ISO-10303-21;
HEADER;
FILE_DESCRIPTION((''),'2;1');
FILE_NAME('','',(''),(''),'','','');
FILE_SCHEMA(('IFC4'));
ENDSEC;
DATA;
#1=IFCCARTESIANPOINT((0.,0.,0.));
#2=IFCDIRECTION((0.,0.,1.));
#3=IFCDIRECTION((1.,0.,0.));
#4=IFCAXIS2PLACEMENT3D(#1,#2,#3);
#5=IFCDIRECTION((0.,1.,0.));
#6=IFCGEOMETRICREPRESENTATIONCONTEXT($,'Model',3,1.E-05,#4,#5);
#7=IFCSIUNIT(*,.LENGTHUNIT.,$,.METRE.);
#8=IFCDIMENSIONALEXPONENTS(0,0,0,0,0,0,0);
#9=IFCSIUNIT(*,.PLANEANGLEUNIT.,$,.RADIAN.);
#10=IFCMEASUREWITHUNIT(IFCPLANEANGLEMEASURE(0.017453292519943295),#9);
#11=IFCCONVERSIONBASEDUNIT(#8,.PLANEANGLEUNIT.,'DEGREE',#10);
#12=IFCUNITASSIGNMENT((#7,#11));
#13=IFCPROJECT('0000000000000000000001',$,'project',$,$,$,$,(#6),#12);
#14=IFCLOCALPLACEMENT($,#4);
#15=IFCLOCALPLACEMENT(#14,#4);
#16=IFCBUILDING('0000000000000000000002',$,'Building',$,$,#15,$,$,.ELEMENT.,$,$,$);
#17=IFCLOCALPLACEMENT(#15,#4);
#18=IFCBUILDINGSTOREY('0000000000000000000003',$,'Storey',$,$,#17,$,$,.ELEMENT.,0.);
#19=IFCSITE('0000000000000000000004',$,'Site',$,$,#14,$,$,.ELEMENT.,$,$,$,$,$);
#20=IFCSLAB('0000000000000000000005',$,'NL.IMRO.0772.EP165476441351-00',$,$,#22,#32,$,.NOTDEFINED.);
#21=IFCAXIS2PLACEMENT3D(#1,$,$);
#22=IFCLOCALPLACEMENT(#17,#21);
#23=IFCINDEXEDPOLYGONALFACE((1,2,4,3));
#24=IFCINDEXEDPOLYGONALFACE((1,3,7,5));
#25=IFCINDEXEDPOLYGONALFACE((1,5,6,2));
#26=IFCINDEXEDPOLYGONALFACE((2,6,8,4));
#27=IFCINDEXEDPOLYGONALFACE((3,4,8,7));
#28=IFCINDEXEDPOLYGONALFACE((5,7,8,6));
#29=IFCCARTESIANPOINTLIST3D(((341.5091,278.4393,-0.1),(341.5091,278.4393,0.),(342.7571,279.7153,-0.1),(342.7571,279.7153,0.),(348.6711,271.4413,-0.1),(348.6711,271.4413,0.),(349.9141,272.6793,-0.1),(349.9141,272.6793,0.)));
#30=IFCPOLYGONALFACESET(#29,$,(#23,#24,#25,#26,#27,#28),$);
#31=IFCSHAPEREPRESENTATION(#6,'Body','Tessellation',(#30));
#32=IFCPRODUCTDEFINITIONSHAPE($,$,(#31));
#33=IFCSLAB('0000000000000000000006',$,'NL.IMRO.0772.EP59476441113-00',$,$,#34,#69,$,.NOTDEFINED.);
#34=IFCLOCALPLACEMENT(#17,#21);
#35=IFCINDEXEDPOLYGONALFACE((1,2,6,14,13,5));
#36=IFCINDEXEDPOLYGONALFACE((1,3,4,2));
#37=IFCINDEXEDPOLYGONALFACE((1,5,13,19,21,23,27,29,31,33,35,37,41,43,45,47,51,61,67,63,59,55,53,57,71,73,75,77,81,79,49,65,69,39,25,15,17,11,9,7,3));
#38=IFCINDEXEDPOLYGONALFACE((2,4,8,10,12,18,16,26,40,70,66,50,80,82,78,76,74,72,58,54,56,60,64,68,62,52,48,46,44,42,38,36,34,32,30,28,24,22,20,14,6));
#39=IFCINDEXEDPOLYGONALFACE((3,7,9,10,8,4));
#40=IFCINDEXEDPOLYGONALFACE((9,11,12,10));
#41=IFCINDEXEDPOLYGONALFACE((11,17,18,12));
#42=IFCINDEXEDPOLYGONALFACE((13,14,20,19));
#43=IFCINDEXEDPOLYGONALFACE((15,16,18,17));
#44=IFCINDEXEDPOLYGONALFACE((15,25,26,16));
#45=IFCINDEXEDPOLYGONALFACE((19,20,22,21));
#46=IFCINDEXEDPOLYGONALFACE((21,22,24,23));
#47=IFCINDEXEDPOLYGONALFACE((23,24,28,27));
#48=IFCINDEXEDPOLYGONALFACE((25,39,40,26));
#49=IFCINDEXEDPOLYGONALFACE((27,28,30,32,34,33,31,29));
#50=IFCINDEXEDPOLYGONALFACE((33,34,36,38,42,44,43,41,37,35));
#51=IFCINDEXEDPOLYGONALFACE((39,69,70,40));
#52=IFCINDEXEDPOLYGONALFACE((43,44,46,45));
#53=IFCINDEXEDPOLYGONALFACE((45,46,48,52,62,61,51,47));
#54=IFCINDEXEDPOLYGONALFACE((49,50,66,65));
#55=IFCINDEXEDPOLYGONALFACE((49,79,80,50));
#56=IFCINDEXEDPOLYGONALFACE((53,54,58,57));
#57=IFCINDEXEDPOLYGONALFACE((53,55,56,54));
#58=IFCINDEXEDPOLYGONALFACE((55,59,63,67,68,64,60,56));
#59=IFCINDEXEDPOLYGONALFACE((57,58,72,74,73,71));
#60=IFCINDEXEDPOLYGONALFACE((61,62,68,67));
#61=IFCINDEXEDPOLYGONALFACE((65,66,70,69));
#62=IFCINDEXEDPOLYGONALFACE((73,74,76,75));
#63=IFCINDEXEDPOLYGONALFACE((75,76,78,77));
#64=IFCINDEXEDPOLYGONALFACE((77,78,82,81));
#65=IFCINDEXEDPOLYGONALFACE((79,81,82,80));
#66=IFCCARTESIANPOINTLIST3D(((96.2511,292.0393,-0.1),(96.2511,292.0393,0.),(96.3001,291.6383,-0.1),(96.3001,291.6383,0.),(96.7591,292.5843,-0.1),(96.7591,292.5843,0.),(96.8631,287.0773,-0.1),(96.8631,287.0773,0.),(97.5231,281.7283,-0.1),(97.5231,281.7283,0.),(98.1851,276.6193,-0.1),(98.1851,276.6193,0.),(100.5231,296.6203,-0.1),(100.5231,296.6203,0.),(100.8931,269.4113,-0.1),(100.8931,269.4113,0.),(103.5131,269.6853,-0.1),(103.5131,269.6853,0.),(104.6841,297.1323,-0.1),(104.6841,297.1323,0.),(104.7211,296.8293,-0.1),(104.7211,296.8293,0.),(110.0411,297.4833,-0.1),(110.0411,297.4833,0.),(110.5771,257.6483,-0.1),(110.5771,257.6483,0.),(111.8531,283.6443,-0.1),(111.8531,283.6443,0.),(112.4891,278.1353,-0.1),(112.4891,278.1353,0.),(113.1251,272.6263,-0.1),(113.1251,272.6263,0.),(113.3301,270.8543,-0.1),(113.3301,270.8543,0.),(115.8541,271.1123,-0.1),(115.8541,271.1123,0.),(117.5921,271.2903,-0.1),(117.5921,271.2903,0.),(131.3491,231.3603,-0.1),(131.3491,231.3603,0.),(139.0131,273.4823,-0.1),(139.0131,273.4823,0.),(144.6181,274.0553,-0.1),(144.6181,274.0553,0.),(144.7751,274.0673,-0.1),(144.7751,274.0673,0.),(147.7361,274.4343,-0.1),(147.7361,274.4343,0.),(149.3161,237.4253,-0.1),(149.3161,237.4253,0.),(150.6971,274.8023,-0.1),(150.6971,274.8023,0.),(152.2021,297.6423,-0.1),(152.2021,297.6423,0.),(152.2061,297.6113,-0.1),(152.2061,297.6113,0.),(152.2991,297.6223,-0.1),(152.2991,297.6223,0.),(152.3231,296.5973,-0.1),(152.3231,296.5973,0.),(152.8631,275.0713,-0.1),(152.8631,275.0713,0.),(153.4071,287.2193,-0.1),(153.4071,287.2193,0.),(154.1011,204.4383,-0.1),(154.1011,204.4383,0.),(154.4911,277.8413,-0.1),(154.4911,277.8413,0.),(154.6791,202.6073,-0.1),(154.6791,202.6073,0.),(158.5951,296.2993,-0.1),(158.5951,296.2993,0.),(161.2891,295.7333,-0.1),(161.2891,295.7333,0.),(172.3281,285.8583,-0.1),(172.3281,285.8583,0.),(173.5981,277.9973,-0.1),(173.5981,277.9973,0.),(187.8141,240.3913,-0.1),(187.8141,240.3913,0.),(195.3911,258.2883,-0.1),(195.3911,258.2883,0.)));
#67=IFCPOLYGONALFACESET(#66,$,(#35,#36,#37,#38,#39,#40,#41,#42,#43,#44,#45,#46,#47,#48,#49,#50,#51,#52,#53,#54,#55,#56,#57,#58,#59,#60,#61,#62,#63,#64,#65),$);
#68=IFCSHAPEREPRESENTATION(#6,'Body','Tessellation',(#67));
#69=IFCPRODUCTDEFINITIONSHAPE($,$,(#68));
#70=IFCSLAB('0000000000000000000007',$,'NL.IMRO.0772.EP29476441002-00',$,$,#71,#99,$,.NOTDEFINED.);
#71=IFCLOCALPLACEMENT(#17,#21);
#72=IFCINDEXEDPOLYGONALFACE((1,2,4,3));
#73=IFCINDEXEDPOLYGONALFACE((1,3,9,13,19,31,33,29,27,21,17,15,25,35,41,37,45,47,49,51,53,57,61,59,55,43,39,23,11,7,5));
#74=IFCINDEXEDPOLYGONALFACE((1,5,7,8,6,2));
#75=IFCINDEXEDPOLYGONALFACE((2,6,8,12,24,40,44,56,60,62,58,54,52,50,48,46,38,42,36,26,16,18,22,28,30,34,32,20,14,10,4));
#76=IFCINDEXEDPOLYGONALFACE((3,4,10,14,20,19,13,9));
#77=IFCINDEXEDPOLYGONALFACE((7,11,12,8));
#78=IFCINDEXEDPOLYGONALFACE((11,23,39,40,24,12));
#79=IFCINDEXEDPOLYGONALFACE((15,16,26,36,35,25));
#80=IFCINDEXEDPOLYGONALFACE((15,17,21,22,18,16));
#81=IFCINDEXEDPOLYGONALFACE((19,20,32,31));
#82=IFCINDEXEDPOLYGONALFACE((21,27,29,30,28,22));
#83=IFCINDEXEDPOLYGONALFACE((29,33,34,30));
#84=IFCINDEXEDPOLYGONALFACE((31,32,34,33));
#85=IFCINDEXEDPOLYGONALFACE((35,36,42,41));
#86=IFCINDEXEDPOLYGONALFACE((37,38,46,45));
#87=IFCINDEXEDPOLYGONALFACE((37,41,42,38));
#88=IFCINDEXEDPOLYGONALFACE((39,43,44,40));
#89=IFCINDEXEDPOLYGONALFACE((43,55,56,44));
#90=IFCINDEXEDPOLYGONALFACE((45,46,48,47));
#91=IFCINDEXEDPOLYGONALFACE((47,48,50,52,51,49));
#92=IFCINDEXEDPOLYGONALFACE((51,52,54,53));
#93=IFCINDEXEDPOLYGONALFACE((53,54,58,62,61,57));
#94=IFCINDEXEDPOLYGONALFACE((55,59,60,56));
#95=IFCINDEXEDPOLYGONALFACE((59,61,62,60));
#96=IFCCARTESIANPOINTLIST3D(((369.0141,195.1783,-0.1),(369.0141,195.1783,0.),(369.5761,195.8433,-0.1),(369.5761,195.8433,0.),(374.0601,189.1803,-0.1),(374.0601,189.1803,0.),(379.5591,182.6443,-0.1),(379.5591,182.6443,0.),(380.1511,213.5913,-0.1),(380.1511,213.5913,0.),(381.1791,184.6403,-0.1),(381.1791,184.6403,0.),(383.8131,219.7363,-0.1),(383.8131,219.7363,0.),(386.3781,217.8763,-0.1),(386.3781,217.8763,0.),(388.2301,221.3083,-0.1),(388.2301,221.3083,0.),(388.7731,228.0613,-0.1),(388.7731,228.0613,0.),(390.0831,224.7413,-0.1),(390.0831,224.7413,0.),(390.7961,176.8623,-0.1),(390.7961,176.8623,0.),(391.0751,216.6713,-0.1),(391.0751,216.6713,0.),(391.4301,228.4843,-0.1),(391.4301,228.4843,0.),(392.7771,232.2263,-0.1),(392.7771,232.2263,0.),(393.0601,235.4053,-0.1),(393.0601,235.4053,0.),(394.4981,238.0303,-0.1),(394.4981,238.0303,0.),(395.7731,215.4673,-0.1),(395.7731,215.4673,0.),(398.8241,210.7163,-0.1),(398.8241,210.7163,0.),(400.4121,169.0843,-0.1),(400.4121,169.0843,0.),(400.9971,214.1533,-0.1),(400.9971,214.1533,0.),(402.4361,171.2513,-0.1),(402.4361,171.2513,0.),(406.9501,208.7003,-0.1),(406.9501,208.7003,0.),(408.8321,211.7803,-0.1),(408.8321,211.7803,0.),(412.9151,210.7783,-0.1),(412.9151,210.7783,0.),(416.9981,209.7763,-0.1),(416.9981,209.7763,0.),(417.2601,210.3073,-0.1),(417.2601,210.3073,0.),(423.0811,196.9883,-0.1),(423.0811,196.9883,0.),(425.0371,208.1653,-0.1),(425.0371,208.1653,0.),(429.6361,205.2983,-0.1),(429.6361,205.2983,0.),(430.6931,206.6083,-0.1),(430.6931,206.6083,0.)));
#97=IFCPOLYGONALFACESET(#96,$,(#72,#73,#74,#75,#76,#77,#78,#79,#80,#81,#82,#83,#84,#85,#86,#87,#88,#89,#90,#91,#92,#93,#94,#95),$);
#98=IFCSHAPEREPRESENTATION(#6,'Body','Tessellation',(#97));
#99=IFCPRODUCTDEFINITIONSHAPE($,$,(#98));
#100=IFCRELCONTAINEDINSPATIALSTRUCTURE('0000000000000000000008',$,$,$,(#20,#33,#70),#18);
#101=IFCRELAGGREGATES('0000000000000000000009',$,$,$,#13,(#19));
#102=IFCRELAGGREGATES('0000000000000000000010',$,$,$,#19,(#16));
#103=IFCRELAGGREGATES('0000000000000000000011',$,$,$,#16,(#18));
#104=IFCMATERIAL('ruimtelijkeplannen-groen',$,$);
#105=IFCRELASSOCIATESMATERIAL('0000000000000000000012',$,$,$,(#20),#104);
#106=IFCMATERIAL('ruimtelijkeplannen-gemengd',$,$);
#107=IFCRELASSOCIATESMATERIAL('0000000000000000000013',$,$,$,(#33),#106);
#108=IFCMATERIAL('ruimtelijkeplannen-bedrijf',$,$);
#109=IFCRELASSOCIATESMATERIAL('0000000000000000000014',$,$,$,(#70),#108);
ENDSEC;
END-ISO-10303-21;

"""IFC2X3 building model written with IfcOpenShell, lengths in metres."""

from ifc_helpers import new_model, entity, si_unit, converted_unit, direction, frame, origin_with_axes, place, context, project, spatial, polyline, outline, extrude, material, element, save


model = new_model("IFC2X3")

# Units and contexts
model_context = context("Model", 3, precision=1e-05, world=origin_with_axes(), true_north=direction((0.0, 1.0, 0.0)))
ifc_project = project(units=[si_unit("LENGTHUNIT", "METRE"), converted_unit("PLANEANGLEUNIT", "DEGREE", entity("IfcPlaneAngleMeasure", 0.017453292519943295), si_unit("PLANEANGLEUNIT", "RADIAN"), dimensions=[0, 0, 0, 0, 0, 0, 0])], contexts=[model_context])

# Site, building, storey
site_placement = place(None, origin_with_axes())
site = spatial("IfcSite", under=ifc_project, at=site_placement, Name="Site", CompositionType="ELEMENT")
building_placement = place(site_placement, origin_with_axes())
building = spatial("IfcBuilding", under=site, at=building_placement, Name="Building", CompositionType="ELEMENT")
storey_placement = place(building_placement, origin_with_axes())
storey = spatial("IfcBuildingStorey", under=building, at=storey_placement, Name="Storey", CompositionType="ELEMENT", Elevation=0.0)

# Slabs
ifc_material_1 = material(Name="ruimtelijkeplannen-groen")
ifc_material_2 = material(Name="ruimtelijkeplannen-bedrijf")
ifc_material_3 = material(Name="ruimtelijkeplannen-gemengd")
slab_1_placement = place(storey_placement, frame((0.0, 0.0, -0.1), z_axis=(0.0, 0.0, 1.0), x_axis=(1.0, 0.0, 0.0)))
element("IfcSlab", 1, at=slab_1_placement, inside=storey, material=ifc_material_1, Name="NL.IMRO.0772.EP165476441351-00", PredefinedType="NOTDEFINED", context=model_context, shape_type="SweptSolid", body=[
    extrude(outline(polyline([(341.5091, 278.4393), (342.7571, 279.7153), (349.9141, 272.6793), (348.6711, 271.4413), (341.5091, 278.4393)])), origin_with_axes(), (0.0, 0.0, 1.0), 0.1),
])
slab_2_placement = place(storey_placement, frame((0.0, 0.0, -0.1), z_axis=(0.0, 0.0, 1.0), x_axis=(1.0, 0.0, 0.0)))
element("IfcSlab", 2, at=slab_2_placement, inside=storey, material=ifc_material_3, Name="NL.IMRO.0772.EP59476441113-00", PredefinedType="NOTDEFINED", context=model_context, shape_type="SweptSolid", body=[
    extrude(outline(polyline([(152.2991, 297.6223), (158.5951, 296.2993), (161.2891, 295.7333), (172.3281, 285.8583), (173.5981, 277.9973), (195.3911, 258.2883), (187.8141, 240.3913), (149.3161, 237.4253), (154.1011, 204.4383), (154.6791, 202.6073), (131.3491, 231.3603), (110.5771, 257.6483), (100.8931, 269.4113), (103.5131, 269.6853), (98.1851, 276.6193), (97.5231, 281.7283), (96.8631, 287.0773), (96.3001, 291.6383), (96.2511, 292.0393), (96.7591, 292.5843), (100.5231, 296.6203), (104.6841, 297.1323), (104.7211, 296.8293), (110.0411, 297.4833), (111.8531, 283.6443), (112.4891, 278.1353), (113.1251, 272.6263), (113.3301, 270.8543), (115.8541, 271.1123), (117.5921, 271.2903), (139.0131, 273.4823), (144.6181, 274.0553), (144.7751, 274.0673), (147.7361, 274.4343), (150.6971, 274.8023), (152.8631, 275.0713), (154.4911, 277.8413), (153.4071, 287.2193), (152.3231, 296.5973), (152.2061, 297.6113), (152.2021, 297.6423), (152.2991, 297.6223)])), origin_with_axes(), (0.0, 0.0, 1.0), 0.1),
])
slab_3_placement = place(storey_placement, frame((0.0, 0.0, -0.1), z_axis=(0.0, 0.0, 1.0), x_axis=(1.0, 0.0, 0.0)))
element("IfcSlab", 3, at=slab_3_placement, inside=storey, material=ifc_material_2, Name="NL.IMRO.0772.EP29476441002-00", PredefinedType="NOTDEFINED", context=model_context, shape_type="SweptSolid", body=[
    extrude(outline(polyline([(369.0141, 195.1783), (369.5761, 195.8433), (380.1511, 213.5913), (383.8131, 219.7363), (388.7731, 228.0613), (393.0601, 235.4053), (394.4981, 238.0303), (392.7771, 232.2263), (391.4301, 228.4843), (390.0831, 224.7413), (388.2301, 221.3083), (386.3781, 217.8763), (391.0751, 216.6713), (395.7731, 215.4673), (400.9971, 214.1533), (398.8241, 210.7163), (406.9501, 208.7003), (408.8321, 211.7803), (412.9151, 210.7783), (416.9981, 209.7763), (417.2601, 210.3073), (425.0371, 208.1653), (430.6931, 206.6083), (429.6361, 205.2983), (423.0811, 196.9883), (402.4361, 171.2513), (400.4121, 169.0843), (390.7961, 176.8623), (381.1791, 184.6403), (379.5591, 182.6443), (374.0601, 189.1803), (369.0141, 195.1783)])), origin_with_axes(), (0.0, 0.0, 1.0), 0.1),
])

save(model, "model.ifc")
